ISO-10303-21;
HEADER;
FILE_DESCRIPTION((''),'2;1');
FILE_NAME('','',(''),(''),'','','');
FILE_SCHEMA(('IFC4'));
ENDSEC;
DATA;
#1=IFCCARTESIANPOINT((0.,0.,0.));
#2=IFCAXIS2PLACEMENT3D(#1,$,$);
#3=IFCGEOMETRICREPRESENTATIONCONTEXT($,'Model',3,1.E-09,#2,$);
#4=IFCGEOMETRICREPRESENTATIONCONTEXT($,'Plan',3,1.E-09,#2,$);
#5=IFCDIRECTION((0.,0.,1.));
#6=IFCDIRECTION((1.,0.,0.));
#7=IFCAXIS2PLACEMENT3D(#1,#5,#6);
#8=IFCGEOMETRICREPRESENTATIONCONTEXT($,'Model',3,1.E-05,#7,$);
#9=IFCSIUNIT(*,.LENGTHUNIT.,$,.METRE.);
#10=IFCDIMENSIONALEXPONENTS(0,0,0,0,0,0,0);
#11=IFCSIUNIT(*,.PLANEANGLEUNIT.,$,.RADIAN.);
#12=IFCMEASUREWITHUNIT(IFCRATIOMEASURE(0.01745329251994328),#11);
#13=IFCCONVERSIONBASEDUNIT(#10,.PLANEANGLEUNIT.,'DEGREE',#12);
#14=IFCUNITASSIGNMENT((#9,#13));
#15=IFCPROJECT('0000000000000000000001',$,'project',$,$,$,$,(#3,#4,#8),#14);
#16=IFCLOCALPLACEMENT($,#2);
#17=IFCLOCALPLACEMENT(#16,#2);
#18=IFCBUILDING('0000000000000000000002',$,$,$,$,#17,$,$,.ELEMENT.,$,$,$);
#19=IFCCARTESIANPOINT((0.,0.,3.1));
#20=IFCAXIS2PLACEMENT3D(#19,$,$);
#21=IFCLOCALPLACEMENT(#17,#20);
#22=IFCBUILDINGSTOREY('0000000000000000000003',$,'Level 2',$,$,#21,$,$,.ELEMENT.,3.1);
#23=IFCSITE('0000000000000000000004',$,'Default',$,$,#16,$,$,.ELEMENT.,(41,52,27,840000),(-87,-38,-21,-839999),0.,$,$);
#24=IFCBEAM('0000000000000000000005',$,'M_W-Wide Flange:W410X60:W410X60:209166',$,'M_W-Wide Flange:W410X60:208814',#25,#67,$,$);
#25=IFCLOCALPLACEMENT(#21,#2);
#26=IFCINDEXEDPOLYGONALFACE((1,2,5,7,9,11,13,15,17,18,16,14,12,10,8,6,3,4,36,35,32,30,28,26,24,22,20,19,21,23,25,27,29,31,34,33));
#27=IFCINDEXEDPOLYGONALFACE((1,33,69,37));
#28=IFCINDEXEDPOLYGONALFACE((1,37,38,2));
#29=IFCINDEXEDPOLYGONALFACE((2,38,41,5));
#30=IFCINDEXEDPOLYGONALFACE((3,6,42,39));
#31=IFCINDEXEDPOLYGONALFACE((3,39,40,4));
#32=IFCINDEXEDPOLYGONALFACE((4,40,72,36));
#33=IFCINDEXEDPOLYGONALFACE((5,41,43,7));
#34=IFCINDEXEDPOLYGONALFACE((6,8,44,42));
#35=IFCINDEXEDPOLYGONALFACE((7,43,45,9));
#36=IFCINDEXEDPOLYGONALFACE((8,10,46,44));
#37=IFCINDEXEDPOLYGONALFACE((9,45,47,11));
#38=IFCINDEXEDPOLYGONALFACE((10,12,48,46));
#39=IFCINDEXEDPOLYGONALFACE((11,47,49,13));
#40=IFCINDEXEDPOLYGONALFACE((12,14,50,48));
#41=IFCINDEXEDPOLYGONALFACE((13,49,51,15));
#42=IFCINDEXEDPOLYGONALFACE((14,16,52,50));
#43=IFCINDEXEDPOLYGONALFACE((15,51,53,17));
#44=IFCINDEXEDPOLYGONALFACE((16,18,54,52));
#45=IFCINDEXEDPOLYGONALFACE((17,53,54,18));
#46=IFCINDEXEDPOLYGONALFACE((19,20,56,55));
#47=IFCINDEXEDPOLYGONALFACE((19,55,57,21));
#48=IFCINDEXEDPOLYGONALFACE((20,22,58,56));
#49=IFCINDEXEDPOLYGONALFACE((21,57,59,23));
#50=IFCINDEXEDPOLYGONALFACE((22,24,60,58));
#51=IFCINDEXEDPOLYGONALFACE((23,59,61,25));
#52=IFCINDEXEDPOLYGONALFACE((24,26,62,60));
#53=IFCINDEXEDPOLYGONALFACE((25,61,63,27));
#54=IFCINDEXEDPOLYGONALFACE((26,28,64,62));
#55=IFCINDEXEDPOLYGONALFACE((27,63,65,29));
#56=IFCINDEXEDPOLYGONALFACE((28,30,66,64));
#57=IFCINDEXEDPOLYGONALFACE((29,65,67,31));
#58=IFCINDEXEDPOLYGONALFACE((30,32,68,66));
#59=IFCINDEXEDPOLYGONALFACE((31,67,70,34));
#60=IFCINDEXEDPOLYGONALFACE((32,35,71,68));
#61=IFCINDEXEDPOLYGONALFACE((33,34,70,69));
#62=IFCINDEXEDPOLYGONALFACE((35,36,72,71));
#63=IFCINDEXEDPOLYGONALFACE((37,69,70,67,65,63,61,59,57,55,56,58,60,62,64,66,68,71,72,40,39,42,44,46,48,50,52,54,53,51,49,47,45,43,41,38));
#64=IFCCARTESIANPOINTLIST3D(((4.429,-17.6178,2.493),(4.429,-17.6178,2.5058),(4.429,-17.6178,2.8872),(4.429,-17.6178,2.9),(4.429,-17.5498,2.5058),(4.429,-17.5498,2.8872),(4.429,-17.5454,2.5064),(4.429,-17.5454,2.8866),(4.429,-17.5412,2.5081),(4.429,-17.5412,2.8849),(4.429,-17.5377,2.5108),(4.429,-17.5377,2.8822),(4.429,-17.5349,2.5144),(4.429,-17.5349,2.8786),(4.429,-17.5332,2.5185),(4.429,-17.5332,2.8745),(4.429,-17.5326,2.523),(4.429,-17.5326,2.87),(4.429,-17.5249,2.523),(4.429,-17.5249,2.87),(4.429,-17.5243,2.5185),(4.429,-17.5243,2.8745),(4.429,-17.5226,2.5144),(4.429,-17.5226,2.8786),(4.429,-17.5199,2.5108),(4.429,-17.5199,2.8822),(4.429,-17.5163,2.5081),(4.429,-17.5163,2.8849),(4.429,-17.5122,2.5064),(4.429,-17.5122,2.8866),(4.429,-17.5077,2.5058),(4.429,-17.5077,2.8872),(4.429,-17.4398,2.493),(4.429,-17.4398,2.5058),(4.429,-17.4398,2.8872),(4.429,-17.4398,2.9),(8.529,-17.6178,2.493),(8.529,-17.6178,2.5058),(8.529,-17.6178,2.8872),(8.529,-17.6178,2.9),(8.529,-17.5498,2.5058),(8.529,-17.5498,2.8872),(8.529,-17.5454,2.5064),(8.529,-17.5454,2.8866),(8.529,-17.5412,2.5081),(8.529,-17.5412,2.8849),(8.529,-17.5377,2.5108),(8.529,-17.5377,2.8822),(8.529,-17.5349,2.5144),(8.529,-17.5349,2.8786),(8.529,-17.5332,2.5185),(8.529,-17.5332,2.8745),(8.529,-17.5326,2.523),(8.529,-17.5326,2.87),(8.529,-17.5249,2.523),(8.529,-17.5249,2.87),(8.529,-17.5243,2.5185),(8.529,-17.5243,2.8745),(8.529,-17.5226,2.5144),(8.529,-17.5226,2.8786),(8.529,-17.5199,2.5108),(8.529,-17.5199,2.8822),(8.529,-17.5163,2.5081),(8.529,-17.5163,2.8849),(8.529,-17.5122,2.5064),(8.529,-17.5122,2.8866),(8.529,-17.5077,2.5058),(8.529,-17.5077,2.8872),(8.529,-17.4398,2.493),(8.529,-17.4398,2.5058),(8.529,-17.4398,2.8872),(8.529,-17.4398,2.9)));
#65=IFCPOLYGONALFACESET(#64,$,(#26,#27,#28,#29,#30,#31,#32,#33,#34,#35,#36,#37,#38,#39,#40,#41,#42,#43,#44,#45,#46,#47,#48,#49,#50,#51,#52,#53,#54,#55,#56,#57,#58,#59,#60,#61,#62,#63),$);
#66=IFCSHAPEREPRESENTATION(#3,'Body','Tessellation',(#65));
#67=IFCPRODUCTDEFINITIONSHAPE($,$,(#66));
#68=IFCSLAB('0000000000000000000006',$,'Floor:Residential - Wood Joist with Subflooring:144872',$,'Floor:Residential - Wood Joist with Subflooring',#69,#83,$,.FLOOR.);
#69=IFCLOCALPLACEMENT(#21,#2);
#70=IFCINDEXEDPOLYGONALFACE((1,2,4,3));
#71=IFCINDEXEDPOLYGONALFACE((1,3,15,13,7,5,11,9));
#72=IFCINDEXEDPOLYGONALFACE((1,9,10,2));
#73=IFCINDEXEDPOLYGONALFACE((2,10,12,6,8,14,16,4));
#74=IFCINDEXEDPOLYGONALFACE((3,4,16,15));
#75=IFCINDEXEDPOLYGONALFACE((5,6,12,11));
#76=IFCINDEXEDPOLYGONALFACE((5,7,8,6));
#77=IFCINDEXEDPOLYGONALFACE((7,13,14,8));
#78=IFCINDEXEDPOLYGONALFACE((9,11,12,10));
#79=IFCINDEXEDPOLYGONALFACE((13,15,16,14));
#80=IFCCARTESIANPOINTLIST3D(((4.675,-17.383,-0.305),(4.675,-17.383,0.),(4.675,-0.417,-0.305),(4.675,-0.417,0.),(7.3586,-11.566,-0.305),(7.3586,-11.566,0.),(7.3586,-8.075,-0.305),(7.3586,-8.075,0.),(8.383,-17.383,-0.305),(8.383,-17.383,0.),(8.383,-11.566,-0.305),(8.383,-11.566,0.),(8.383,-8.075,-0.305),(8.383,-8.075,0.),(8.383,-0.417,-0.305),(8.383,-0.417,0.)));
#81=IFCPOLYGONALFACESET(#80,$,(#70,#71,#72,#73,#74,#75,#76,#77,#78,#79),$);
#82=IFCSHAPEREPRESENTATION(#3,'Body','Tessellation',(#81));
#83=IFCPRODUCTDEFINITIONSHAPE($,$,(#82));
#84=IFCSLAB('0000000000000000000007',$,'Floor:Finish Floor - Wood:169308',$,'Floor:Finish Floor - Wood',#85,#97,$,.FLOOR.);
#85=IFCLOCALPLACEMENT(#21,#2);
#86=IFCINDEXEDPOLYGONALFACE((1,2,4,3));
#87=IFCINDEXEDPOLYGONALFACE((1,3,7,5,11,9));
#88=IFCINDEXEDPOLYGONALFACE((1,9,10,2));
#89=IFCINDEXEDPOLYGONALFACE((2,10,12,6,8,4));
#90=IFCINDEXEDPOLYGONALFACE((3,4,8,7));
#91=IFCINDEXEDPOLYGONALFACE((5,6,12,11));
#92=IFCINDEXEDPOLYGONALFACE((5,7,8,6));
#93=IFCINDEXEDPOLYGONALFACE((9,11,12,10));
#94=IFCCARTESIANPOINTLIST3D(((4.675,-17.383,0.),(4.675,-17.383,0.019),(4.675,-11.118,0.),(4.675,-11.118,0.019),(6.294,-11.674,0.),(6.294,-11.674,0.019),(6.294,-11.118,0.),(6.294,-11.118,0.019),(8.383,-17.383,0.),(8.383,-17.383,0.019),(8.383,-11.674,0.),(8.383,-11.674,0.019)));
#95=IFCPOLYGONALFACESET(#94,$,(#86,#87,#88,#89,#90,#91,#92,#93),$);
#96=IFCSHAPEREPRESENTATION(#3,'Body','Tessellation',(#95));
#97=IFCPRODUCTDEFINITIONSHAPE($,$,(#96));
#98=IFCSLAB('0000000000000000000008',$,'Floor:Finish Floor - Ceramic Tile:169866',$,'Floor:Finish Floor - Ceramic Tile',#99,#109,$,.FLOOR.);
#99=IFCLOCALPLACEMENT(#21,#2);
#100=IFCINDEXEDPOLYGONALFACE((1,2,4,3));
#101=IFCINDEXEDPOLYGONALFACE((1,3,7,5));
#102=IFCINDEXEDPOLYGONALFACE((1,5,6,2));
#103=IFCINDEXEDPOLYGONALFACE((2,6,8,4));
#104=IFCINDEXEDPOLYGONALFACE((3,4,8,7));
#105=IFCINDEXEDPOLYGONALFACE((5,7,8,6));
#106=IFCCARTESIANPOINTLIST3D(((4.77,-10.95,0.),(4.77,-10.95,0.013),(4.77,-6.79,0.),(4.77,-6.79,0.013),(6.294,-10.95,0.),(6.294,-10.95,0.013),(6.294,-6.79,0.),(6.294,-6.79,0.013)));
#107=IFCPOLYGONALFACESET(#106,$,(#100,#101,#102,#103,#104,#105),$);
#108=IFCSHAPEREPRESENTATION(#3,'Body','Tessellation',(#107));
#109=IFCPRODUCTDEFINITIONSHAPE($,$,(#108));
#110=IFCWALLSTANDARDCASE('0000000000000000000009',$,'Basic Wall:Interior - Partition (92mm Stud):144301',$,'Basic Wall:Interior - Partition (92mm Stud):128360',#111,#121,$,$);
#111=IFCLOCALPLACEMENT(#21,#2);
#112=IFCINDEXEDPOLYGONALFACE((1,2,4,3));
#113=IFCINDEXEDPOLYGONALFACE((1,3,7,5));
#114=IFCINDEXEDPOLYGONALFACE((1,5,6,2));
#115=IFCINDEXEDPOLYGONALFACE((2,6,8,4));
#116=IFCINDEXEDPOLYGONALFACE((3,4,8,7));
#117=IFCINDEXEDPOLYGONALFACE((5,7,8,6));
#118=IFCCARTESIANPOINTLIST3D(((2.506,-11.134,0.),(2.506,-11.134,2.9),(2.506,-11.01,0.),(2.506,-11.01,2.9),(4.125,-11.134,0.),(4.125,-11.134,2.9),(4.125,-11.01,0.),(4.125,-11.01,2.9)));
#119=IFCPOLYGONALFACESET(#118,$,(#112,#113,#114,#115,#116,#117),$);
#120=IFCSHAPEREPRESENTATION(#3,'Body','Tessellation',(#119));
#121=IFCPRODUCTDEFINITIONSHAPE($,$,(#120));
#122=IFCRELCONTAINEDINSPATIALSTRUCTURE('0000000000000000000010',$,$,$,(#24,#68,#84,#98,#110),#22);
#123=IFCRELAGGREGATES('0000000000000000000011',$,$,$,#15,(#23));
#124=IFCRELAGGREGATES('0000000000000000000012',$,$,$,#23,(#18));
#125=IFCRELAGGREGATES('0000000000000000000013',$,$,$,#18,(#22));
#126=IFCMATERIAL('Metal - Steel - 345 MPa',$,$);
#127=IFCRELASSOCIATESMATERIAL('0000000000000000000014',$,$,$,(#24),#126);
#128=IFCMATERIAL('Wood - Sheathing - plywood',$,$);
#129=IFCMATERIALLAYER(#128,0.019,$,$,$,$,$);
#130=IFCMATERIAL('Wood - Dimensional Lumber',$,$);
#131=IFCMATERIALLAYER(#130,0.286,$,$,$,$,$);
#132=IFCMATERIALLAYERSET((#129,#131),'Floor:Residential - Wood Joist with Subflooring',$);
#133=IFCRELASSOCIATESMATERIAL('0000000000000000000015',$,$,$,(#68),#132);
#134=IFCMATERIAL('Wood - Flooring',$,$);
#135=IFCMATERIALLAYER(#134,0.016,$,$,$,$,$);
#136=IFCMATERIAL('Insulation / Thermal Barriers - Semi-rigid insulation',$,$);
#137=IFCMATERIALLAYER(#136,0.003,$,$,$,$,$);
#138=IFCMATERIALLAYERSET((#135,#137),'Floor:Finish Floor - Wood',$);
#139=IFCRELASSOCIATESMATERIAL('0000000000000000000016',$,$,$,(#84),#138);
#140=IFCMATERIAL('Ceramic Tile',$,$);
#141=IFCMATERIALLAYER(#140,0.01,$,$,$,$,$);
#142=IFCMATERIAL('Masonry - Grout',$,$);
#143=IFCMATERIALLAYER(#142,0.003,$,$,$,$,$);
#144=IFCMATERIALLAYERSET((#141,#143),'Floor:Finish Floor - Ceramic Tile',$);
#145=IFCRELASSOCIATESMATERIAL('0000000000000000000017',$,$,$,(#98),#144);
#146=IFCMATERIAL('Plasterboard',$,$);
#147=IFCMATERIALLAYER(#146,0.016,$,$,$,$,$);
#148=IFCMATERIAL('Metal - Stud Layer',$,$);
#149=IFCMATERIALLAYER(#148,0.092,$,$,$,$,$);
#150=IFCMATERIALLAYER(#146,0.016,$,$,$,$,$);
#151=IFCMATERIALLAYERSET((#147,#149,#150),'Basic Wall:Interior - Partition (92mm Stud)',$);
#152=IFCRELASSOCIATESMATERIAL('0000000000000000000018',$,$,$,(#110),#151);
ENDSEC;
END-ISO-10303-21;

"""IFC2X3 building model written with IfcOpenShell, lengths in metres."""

from ifc_helpers import new_model, entity, si_unit, converted_unit, frame, frame_2d, origin, origin_with_axes, place, context, project, spatial, polyline, circle_curve, parameter, trimmed, segment, composite_curve, rectangle, outline, extrude, material, layer, layer_set, layer_usage, element, save


model = new_model("IFC2X3")

# Units and contexts
model_context_1 = context("Model", 3, precision=1e-09, world=origin())
plan_context = context("Plan", 3, precision=1e-09, world=origin())
model_context_2 = context("Model", 3, precision=1e-05, world=origin_with_axes())
ifc_project = project(units=[si_unit("LENGTHUNIT", "METRE"), converted_unit("PLANEANGLEUNIT", "DEGREE", entity("IfcRatioMeasure", 0.01745329251994328), si_unit("PLANEANGLEUNIT", "RADIAN"), dimensions=[0, 0, 0, 0, 0, 0, 0])], contexts=[model_context_1, plan_context, model_context_2])

# Site, building, storey
site_placement = place(None, origin())
site = spatial("IfcSite", under=ifc_project, at=site_placement, Name="Default", CompositionType="ELEMENT", RefLatitude=(41, 52, 27, 840000), RefLongitude=(-87, -38, -21, -839999), RefElevation=0.0)
building_placement = place(site_placement, origin())
building = spatial("IfcBuilding", under=site, at=building_placement, CompositionType="ELEMENT")
storey_placement = place(building_placement, frame((0.0, 0.0, 3.1)))
storey = spatial("IfcBuildingStorey", under=building, at=storey_placement, Name="Level 2", CompositionType="ELEMENT", Elevation=3.1)

# Beam
ifc_material_1 = material(Name="Metal - Steel - 345 MPa")
beam_placement = place(storey_placement, frame((4.429, -17.5288, 2.9), z_axis=(0.0, 0.0, 1.0), x_axis=(0.0, -1.0, 0.0)))
element("IfcBeam", 1, at=beam_placement, inside=storey, material=ifc_material_1, Name="M_W-Wide Flange:W410X60:W410X60:209166", ObjectType="M_W-Wide Flange:W410X60:208814", context=model_context_1, shape_type="SweptSolid", body=[
    extrude(outline(composite_curve([segment(polyline([(-0.089, -0.1907), (-0.089, -0.2035)]), True, "CONTINUOUS"), segment(polyline([(-0.089, -0.2035), (0.089, -0.2035)]), True, "CONTINUOUS"), segment(polyline([(0.089, -0.2035), (0.089, -0.1907)]), True, "CONTINUOUS"), segment(polyline([(0.089, -0.1907), (0.021, -0.1907)]), True, "CONTINUOUS"), segment(trimmed(circle_curve(frame_2d((0.021, -0.1735), x_axis=(0.0, -1.0)), 0.0172), [parameter(270.0)], [parameter(360.0)], True, "PARAMETER"), False, "CONTINUOUS"), segment(polyline([(0.0038, -0.1735), (0.0038, 0.1735)]), True, "CONTINUOUS"), segment(trimmed(circle_curve(frame_2d((0.021, 0.1735), x_axis=(-1.0, 0.0)), 0.0172), [parameter(270.0)], [parameter(360.0)], True, "PARAMETER"), False, "CONTINUOUS"), segment(polyline([(0.021, 0.1907), (0.089, 0.1907)]), True, "CONTINUOUS"), segment(polyline([(0.089, 0.1907), (0.089, 0.2035)]), True, "CONTINUOUS"), segment(polyline([(0.089, 0.2035), (-0.089, 0.2035)]), True, "CONTINUOUS"), segment(polyline([(-0.089, 0.2035), (-0.089, 0.1907)]), True, "CONTINUOUS"), segment(polyline([(-0.089, 0.1907), (-0.0211, 0.1907)]), True, "CONTINUOUS"), segment(trimmed(circle_curve(frame_2d((-0.0211, 0.1735), x_axis=(0.0, 1.0)), 0.0172), [parameter(270.0)], [parameter(0.0)], True, "PARAMETER"), False, "CONTINUOUS"), segment(polyline([(-0.0039, 0.1735), (-0.0039, -0.1735)]), True, "CONTINUOUS"), segment(trimmed(circle_curve(frame_2d((-0.0211, -0.1735), x_axis=(1.0, 0.0)), 0.0172), [parameter(270.0)], [parameter(0.0)], True, "PARAMETER"), False, "CONTINUOUS"), segment(polyline([(-0.0211, -0.1907), (-0.089, -0.1907)]), True, "CONTINUOUS")], self_intersect=False)), frame((0.0, 0.0, -0.2035), z_axis=(0.0, -1.0, 0.0), x_axis=(1.0, 0.0, 0.0)), (0.0, 0.0, -1.0), 4.1),
])

# Slabs
ifc_material_2 = material(Name="Wood - Sheathing - plywood")
ifc_layer_1 = layer(ifc_material_2, 0.019)
ifc_material_3 = material(Name="Wood - Dimensional Lumber")
ifc_layer_2 = layer(ifc_material_3, 0.286)
ifc_layer_set_1 = layer_set([ifc_layer_1, ifc_layer_2], Name="Floor:Residential - Wood Joist with Subflooring")
ifc_layer_usage_1 = layer_usage(ifc_layer_set_1, "AXIS3", "POSITIVE", 0.0)
slab_1_placement = place(storey_placement, frame((4.675, -17.383, -0.305)))
element("IfcSlab", 2, at=slab_1_placement, inside=storey, material=ifc_layer_usage_1, Name="Floor:Residential - Wood Joist with Subflooring:144872", ObjectType="Floor:Residential - Wood Joist with Subflooring", PredefinedType="FLOOR", context=model_context_1, shape_type="SweptSolid", body=[
    extrude(outline(polyline([(-1.854, 8.483), (-1.854, 0.825), (-0.8296, 0.825), (-0.8296, -2.666), (-1.854, -2.666), (-1.854, -8.483), (1.854, -8.483), (1.854, 8.483), (-1.854, 8.483)])), frame((1.854, 8.483, 0.305), z_axis=(0.0, 0.0, -1.0), x_axis=(-1.0, 0.0, 0.0)), (0.0, 0.0, 1.0), 0.305),
])
ifc_material_4 = material(Name="Wood - Flooring")
ifc_layer_3 = layer(ifc_material_4, 0.016)
ifc_material_5 = material(Name="Insulation / Thermal Barriers - Semi-rigid insulation")
ifc_layer_4 = layer(ifc_material_5, 0.003)
ifc_layer_set_2 = layer_set([ifc_layer_3, ifc_layer_4], Name="Floor:Finish Floor - Wood")
ifc_layer_usage_2 = layer_usage(ifc_layer_set_2, "AXIS3", "POSITIVE", 0.0)
slab_2_placement = place(storey_placement, frame((4.675, -17.383, 0.0)))
element("IfcSlab", 3, at=slab_2_placement, inside=storey, material=ifc_layer_usage_2, Name="Floor:Finish Floor - Wood:169308", ObjectType="Floor:Finish Floor - Wood", PredefinedType="FLOOR", context=model_context_1, shape_type="SweptSolid", body=[
    extrude(outline(polyline([(-1.854, 2.5765), (-1.854, -3.1325), (1.854, -3.1325), (1.854, 3.1325), (0.235, 3.1325), (0.235, 2.5765), (-1.854, 2.5765)])), frame((1.854, 3.1325, 0.019), z_axis=(0.0, 0.0, -1.0), x_axis=(-1.0, 0.0, 0.0)), (0.0, 0.0, 1.0), 0.019),
])
ifc_material_6 = material(Name="Ceramic Tile")
ifc_layer_5 = layer(ifc_material_6, 0.01)
ifc_material_7 = material(Name="Masonry - Grout")
ifc_layer_6 = layer(ifc_material_7, 0.003)
ifc_layer_set_3 = layer_set([ifc_layer_5, ifc_layer_6], Name="Floor:Finish Floor - Ceramic Tile")
ifc_layer_usage_3 = layer_usage(ifc_layer_set_3, "AXIS3", "POSITIVE", 0.0)
slab_3_placement = place(storey_placement, frame((4.77, -10.95, 0.0)))
element("IfcSlab", 4, at=slab_3_placement, inside=storey, material=ifc_layer_usage_3, Name="Floor:Finish Floor - Ceramic Tile:169866", ObjectType="Floor:Finish Floor - Ceramic Tile", PredefinedType="FLOOR", context=model_context_1, shape_type="SweptSolid", body=[
    extrude(rectangle(XDim=4.16, YDim=1.524, at=frame_2d((0.0, 0.0), x_axis=(0.0, -1.0))), frame((0.762, 2.08, 0.013), z_axis=(0.0, 0.0, -1.0), x_axis=(-1.0, 0.0, 0.0)), (0.0, 0.0, 1.0), 0.013),
])

# Shared definitions
ifc_material_8 = material(Name="Metal - Stud Layer")
ifc_material_9 = material(Name="Plasterboard")

# Wall
ifc_layer_7 = layer(ifc_material_9, 0.016)
ifc_layer_8 = layer(ifc_material_8, 0.092)
ifc_layer_9 = layer(ifc_material_9, 0.016)
ifc_layer_set_4 = layer_set([ifc_layer_7, ifc_layer_8, ifc_layer_9], Name="Basic Wall:Interior - Partition (92mm Stud)")
ifc_layer_usage_4 = layer_usage(ifc_layer_set_4, "AXIS2", "NEGATIVE", 0.062)
wall_1_placement = place(storey_placement, frame((4.125, -11.072, 0.0), z_axis=(0.0, 0.0, 1.0), x_axis=(-1.0, 0.0, 0.0)))
element("IfcWallStandardCase", 5, at=wall_1_placement, inside=storey, material=ifc_layer_usage_4, Name="Basic Wall:Interior - Partition (92mm Stud):144301", ObjectType="Basic Wall:Interior - Partition (92mm Stud):128360", context=model_context_1, shape_type="SweptSolid", body=[
    extrude(rectangle(XDim=1.619, YDim=0.124, at=frame_2d((0.8095, 0.0), x_axis=(-1.0, 0.0))), origin(), (0.0, 0.0, 1.0), 2.9),
])

save(model, "model.ifc")
